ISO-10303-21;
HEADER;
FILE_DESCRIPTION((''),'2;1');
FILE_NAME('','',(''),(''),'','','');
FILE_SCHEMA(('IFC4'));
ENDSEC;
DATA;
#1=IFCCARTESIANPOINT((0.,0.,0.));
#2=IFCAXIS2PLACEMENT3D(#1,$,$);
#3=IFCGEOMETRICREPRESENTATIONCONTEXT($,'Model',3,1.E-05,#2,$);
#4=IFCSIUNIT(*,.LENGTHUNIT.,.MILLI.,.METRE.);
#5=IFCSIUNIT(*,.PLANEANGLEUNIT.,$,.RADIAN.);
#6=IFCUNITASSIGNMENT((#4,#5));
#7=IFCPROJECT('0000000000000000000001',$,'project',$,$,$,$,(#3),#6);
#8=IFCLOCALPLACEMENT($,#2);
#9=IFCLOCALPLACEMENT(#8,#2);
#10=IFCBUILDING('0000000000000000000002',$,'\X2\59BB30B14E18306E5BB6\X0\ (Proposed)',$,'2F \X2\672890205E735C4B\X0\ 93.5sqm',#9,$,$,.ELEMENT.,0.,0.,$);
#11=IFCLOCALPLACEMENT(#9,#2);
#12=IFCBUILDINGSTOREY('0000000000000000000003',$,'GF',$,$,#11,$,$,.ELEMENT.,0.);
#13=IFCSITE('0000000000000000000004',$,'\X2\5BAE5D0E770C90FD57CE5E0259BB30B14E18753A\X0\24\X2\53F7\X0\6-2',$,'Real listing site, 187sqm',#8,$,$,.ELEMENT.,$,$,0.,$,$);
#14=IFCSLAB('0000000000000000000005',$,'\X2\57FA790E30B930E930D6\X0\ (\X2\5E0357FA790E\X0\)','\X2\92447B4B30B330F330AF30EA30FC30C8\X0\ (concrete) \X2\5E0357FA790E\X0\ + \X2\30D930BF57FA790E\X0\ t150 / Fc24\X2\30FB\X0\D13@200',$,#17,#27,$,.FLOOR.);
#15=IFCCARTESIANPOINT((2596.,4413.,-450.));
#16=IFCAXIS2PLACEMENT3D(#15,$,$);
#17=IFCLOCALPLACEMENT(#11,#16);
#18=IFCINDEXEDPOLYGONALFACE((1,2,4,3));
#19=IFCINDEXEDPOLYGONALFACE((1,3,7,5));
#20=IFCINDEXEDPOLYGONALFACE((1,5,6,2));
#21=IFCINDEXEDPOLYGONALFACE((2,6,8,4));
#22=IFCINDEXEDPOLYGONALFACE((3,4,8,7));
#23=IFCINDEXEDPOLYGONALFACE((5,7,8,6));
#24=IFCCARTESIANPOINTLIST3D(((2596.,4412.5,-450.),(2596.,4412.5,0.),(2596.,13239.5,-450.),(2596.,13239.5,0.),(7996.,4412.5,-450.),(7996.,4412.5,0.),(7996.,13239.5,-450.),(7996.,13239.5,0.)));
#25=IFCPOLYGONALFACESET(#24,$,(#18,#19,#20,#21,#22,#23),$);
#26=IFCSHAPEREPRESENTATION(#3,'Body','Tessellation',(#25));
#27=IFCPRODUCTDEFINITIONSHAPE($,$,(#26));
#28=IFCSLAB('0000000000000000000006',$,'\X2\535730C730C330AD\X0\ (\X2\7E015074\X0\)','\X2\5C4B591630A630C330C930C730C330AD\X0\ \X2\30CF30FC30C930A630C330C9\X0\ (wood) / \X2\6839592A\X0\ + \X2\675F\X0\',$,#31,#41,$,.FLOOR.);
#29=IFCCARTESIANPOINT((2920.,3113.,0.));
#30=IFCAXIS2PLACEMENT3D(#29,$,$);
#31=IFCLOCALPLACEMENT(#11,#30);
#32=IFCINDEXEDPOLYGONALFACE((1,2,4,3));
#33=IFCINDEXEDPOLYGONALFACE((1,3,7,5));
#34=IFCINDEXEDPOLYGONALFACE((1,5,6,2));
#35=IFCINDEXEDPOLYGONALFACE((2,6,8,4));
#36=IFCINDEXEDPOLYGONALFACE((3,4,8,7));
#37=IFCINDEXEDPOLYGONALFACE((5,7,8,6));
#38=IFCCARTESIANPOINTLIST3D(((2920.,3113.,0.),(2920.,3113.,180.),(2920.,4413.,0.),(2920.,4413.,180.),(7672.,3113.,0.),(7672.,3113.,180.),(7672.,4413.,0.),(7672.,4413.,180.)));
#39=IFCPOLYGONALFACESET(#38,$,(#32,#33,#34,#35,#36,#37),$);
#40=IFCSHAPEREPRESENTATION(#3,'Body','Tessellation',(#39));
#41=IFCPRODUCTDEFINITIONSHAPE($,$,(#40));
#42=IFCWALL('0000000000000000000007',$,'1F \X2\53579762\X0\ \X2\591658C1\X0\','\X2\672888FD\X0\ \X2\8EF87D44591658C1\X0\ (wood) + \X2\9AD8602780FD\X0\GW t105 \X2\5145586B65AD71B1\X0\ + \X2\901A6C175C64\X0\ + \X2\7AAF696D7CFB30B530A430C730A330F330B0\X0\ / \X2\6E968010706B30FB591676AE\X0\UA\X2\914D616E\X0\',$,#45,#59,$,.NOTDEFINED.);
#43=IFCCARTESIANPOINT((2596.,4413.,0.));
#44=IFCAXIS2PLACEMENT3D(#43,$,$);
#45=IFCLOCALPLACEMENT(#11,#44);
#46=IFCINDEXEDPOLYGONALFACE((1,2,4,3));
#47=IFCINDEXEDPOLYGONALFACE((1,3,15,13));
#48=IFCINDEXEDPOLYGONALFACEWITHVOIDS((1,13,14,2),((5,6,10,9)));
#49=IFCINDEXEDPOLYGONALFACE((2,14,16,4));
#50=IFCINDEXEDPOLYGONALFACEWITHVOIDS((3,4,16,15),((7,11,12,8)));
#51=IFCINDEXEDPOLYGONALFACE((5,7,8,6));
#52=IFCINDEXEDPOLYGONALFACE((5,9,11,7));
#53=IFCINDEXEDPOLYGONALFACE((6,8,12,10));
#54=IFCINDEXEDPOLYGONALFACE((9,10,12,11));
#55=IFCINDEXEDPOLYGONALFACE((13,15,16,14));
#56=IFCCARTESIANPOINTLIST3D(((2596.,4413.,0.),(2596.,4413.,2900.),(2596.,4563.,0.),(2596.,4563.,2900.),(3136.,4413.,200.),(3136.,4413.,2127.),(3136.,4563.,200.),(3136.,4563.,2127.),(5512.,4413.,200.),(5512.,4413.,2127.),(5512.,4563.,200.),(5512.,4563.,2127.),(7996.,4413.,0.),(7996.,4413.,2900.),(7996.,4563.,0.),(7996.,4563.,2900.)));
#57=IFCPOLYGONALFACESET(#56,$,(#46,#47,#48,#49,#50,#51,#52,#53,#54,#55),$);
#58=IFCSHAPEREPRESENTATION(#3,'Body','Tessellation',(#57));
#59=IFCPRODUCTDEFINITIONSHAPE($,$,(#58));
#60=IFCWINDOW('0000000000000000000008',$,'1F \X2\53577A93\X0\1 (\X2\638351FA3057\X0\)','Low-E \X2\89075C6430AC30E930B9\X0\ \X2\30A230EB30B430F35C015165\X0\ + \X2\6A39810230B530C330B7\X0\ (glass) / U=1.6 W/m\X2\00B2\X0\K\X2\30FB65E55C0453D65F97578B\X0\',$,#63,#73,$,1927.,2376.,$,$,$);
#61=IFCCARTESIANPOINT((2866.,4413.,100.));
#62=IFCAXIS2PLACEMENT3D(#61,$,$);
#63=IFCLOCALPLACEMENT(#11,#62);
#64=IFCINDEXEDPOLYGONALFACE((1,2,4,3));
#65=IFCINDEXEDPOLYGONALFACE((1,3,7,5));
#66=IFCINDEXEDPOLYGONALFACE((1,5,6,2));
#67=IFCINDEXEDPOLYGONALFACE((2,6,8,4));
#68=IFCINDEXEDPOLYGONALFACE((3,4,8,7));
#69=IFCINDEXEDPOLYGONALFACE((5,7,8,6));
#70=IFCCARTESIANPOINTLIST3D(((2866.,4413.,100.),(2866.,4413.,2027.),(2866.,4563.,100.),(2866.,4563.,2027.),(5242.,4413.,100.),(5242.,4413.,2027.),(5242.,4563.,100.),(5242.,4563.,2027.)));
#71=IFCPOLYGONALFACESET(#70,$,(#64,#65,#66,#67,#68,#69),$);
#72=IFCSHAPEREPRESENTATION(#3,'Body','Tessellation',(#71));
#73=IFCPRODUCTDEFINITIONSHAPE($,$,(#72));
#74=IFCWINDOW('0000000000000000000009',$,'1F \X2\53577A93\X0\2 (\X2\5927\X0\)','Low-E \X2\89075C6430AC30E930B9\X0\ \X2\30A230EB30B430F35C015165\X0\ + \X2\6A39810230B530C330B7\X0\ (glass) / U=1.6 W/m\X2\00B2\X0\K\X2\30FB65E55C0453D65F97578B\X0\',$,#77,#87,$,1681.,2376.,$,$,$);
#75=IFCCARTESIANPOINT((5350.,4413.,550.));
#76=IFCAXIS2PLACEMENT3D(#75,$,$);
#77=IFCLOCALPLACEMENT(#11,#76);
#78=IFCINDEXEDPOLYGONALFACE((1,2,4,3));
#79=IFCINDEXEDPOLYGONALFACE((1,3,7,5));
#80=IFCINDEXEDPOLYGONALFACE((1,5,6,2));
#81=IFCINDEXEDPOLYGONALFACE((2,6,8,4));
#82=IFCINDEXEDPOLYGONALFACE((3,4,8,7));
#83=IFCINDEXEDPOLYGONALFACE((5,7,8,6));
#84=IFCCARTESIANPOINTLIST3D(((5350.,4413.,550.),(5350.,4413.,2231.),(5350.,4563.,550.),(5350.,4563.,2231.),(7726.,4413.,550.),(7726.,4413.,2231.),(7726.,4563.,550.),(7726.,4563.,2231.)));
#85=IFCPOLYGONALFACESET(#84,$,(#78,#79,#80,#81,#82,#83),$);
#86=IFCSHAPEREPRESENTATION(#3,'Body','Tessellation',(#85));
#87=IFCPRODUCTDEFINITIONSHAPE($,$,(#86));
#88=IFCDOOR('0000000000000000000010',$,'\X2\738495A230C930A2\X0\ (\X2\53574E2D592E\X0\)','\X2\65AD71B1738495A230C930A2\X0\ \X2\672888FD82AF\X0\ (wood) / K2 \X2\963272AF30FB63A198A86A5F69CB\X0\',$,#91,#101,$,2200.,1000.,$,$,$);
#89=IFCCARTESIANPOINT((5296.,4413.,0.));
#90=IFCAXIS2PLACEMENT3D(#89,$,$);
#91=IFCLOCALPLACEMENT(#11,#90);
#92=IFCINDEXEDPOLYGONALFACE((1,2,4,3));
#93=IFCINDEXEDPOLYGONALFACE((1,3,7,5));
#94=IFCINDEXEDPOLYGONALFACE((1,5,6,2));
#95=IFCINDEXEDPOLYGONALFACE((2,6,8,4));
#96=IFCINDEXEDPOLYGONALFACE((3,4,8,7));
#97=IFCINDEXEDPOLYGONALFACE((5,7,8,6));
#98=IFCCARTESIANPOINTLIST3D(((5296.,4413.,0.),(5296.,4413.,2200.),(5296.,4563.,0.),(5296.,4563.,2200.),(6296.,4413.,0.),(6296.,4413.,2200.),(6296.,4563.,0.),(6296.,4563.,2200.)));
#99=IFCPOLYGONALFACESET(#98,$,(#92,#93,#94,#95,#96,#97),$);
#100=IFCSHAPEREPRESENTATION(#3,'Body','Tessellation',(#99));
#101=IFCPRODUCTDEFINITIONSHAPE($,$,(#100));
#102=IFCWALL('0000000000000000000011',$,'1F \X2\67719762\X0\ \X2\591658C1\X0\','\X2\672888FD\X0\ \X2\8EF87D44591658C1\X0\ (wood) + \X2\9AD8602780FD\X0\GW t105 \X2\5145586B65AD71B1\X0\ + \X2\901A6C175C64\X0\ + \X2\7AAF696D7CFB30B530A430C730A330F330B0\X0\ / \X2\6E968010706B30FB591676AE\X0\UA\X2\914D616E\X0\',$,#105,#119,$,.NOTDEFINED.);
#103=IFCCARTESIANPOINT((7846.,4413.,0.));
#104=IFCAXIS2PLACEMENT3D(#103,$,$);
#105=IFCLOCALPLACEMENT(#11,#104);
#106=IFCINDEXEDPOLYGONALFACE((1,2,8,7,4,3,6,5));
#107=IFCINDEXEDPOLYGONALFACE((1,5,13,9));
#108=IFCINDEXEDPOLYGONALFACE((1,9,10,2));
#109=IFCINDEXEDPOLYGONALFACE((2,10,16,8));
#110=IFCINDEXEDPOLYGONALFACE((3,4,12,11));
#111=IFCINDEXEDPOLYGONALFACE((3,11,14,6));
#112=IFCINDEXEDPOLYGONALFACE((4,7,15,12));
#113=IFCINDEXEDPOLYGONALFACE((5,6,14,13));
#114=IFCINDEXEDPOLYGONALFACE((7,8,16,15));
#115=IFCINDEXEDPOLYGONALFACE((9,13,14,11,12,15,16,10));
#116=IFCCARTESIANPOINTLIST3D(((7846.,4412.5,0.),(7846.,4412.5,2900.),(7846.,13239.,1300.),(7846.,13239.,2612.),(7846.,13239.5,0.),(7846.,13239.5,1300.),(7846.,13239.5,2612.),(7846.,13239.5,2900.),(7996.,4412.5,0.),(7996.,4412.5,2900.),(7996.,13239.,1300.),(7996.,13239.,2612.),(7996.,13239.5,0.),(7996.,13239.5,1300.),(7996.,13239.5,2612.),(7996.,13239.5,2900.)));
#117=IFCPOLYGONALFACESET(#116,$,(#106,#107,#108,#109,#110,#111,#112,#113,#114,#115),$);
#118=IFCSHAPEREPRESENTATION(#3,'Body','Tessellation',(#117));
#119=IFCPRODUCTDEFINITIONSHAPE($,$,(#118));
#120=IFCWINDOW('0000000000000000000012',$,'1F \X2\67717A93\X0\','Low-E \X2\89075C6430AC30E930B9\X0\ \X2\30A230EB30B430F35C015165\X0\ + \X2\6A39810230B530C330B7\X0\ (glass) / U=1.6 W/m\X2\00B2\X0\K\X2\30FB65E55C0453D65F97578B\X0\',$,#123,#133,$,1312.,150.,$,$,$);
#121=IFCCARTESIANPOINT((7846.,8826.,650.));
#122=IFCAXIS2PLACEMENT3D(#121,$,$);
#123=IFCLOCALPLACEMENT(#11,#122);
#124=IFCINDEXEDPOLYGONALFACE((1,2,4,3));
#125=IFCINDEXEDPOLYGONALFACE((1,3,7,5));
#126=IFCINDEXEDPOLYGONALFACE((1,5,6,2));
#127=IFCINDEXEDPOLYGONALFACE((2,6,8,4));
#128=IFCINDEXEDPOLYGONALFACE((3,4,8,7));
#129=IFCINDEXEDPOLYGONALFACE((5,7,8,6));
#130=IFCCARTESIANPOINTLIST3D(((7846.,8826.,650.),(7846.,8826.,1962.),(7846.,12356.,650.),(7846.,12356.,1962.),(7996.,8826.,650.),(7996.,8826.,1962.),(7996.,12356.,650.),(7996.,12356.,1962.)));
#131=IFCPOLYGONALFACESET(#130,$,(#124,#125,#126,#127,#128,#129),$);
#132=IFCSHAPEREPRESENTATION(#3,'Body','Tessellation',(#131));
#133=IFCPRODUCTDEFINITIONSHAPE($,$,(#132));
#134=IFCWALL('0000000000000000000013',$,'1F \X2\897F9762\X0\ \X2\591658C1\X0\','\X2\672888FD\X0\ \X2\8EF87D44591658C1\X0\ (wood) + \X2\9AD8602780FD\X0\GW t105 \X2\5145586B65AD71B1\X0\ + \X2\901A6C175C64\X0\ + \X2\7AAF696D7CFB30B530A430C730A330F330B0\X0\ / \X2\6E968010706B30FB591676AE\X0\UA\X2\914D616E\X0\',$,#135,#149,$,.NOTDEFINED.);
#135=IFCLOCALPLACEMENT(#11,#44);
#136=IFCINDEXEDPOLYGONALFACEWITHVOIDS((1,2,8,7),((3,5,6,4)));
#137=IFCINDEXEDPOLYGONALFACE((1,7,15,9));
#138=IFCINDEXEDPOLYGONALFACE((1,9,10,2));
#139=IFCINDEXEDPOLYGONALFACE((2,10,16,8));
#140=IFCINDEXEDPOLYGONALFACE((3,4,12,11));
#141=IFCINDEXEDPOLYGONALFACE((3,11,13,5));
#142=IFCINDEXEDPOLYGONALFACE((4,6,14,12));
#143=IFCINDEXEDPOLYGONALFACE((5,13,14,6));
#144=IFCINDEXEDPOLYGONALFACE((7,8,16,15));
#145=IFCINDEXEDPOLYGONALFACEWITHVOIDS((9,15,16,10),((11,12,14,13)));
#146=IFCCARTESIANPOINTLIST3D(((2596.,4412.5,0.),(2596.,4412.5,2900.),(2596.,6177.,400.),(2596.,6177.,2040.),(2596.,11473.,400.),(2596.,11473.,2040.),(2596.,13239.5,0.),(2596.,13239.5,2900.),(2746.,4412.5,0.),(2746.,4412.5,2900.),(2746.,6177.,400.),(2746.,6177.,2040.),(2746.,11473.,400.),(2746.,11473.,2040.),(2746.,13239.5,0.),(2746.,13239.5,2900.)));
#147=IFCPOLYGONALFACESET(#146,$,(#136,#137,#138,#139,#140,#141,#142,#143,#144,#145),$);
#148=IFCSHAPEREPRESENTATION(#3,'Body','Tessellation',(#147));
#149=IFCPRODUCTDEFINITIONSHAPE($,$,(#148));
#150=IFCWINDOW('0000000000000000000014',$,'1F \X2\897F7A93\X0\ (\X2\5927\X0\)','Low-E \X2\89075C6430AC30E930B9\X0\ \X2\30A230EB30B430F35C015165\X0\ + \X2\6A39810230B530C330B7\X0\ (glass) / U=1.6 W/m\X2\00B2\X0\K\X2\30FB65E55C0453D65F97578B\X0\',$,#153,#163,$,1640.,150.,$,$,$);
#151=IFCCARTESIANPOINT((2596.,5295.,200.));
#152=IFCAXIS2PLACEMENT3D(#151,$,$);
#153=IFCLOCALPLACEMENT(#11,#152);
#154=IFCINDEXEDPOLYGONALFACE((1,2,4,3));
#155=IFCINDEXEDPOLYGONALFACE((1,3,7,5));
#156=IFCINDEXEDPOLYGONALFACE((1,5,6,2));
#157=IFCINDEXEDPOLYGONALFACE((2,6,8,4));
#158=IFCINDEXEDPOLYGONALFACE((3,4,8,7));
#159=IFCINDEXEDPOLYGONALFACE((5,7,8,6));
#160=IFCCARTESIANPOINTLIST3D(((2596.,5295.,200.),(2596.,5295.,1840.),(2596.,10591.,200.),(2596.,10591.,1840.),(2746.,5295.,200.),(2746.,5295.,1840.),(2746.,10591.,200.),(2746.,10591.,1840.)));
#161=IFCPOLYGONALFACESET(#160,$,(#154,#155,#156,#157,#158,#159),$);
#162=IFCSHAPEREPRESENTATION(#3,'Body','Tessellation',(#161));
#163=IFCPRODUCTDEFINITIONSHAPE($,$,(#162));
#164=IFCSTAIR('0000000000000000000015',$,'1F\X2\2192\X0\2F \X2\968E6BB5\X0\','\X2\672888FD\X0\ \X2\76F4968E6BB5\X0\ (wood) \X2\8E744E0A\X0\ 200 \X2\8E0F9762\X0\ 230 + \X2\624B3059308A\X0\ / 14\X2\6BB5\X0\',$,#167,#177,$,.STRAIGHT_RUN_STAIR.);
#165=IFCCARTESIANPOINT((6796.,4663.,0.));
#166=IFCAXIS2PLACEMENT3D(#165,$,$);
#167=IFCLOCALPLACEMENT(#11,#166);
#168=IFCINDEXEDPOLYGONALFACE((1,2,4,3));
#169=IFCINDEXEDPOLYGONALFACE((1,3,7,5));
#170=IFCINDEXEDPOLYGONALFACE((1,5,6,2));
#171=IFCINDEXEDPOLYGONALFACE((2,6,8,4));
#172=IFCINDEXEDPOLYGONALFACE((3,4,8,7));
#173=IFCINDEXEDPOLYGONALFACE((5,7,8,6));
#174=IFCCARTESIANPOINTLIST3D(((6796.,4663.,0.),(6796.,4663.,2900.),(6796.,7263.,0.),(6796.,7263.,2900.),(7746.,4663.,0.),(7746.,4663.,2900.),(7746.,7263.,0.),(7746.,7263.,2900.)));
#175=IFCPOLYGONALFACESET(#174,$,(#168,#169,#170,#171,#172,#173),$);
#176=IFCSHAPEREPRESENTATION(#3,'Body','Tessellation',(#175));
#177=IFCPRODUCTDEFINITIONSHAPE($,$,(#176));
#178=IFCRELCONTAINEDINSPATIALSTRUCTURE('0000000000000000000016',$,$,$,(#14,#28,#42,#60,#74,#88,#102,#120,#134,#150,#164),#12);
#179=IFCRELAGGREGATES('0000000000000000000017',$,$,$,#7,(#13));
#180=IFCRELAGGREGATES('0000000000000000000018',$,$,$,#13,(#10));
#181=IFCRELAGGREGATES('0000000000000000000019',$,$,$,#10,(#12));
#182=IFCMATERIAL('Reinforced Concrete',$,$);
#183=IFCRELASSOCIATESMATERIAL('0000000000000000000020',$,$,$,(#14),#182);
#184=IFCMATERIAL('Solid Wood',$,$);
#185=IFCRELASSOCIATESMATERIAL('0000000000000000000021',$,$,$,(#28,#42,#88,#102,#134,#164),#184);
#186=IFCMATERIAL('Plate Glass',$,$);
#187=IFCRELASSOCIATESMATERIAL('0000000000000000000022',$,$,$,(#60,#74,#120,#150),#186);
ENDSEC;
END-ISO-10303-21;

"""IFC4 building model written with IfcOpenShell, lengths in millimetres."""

from ifc_helpers import new_model, si_unit, frame, frame_2d, origin, place, context, project, spatial, rectangle, extrude, material, element, fill, save


model = new_model("IFC4")

# Units and contexts
model_context = context("Model", 3, precision=1e-05, world=origin())
ifc_project = project(units=[si_unit("LENGTHUNIT", "METRE", prefix="MILLI"), si_unit("PLANEANGLEUNIT", "RADIAN")], contexts=[model_context])

# Site, building, storey
site_placement = place(None, origin())
site = spatial("IfcSite", under=ifc_project, at=site_placement, Name="宮崎県都城市妻ケ丘町24号6-2", ObjectType="Real listing site, 187sqm", CompositionType="ELEMENT", RefElevation=0.0)
building_placement = place(site_placement, origin())
building = spatial("IfcBuilding", under=site, at=building_placement, Name="妻ケ丘の家 (Proposed)", ObjectType="2F 木造平屋 93.5sqm", CompositionType="ELEMENT", ElevationOfRefHeight=0.0, ElevationOfTerrain=0.0)
storey_placement = place(building_placement, origin())
storey = spatial("IfcBuildingStorey", under=building, at=storey_placement, Name="GF", CompositionType="ELEMENT", Elevation=0.0)

# Slabs
ifc_material_1 = material(Name="Reinforced Concrete")
slab_1_placement = place(storey_placement, frame((2596.0, 4413.0, -450.0)))
element("IfcSlab", 1, at=slab_1_placement, inside=storey, material=ifc_material_1, Name="基礎スラブ (布基礎)", Description="鉄筋コンクリート (concrete) 布基礎 + ベタ基礎 t150 / Fc24・D13@200", PredefinedType="FLOOR", context=model_context, shape_type="SweptSolid", body=[
    extrude(rectangle(XDim=5400.0, YDim=8827.0, at=frame_2d((2700.0, 4413.0))), frame((2596.0, 4413.0, -450.0)), (0.0, 0.0, 1.0), 450.0),
])
ifc_material_2 = material(Name="Solid Wood")
slab_2_placement = place(storey_placement, frame((2920.0, 3113.0, 0.0)))
element("IfcSlab", 2, at=slab_2_placement, inside=storey, material=ifc_material_2, Name="南デッキ (縁側)", Description="屋外ウッドデッキ ハードウッド (wood) / 根太 + 束", PredefinedType="FLOOR", context=model_context, shape_type="SweptSolid", body=[
    extrude(rectangle(XDim=4752.0, YDim=1300.0, at=frame_2d((2376.0, 650.0))), frame((2920.0, 3113.0, 0.0)), (0.0, 0.0, 1.0), 180.0),
])

# Wall, openings, windows, door
wall_1_placement = place(storey_placement, frame((2596.0, 4413.0, 0.0)))
wall_1 = element("IfcWall", 3, at=wall_1_placement, inside=storey, material=ifc_material_2, Name="1F 南面 外壁", Description="木製 軸組外壁 (wood) + 高性能GW t105 充填断熱 + 通気層 + 窯業系サイディング / 準耐火・外皮UA配慮", PredefinedType="NOTDEFINED", context=model_context, shape_type="SweptSolid", body=[
    extrude(rectangle(XDim=5400.0, YDim=150.0, at=frame_2d((2700.0, 75.0))), frame((2596.0, 4413.0, 0.0)), (0.0, 0.0, 1.0), 2900.0),
])
opening_1_placement = place(storey_placement, frame((2866.0, 4413.0, 100.0)))
opening_1 = element("IfcOpeningElement", 4, at=opening_1_placement, cuts=wall_1, PredefinedType="NOTDEFINED", context=model_context, shape_type="SweptSolid", body=[
    extrude(rectangle(XDim=2376.0, YDim=150.0, at=frame_2d((1188.0, 75.0))), frame((2866.0, 4413.0, 100.0)), (0.0, 0.0, 1.0), 1927.0),
])
opening_2_placement = place(storey_placement, frame((5350.0, 4413.0, 550.0)))
opening_2 = element("IfcOpeningElement", 5, at=opening_2_placement, cuts=wall_1, PredefinedType="NOTDEFINED", context=model_context, shape_type="SweptSolid", body=[
    extrude(rectangle(XDim=2376.0, YDim=150.0, at=frame_2d((1188.0, 75.0))), frame((5350.0, 4413.0, 550.0)), (0.0, 0.0, 1.0), 1681.0),
])
opening_3_placement = place(storey_placement, frame((5296.0, 4413.0, 0.0)))
opening_3 = element("IfcOpeningElement", 6, at=opening_3_placement, cuts=wall_1, PredefinedType="NOTDEFINED", context=model_context, shape_type="SweptSolid", body=[
    extrude(rectangle(XDim=1000.0, YDim=150.0, at=frame_2d((500.0, 75.0))), frame((5296.0, 4413.0, 0.0)), (0.0, 0.0, 1.0), 2200.0),
])
ifc_material_3 = material(Name="Plate Glass")
window_1_placement = place(storey_placement, frame((2866.0, 4413.0, 100.0)))
window_1 = element("IfcWindow", 7, at=window_1_placement, inside=storey, material=ifc_material_3, Name="1F 南窓1 (掃出し)", Description="Low-E 複層ガラス アルゴン封入 + 樹脂サッシ (glass) / U=1.6 W/m²K・日射取得型", OverallHeight=1927.0, OverallWidth=2376.0, context=model_context, shape_type="SweptSolid", body=[
    extrude(rectangle(XDim=2376.0, YDim=150.0, at=frame_2d((1188.0, 75.0))), frame((2866.0, 4413.0, 100.0)), (0.0, 0.0, 1.0), 1927.0),
])
fill(opening_1, window_1)
window_2_placement = place(storey_placement, frame((5350.0, 4413.0, 550.0)))
window_2 = element("IfcWindow", 8, at=window_2_placement, inside=storey, material=ifc_material_3, Name="1F 南窓2 (大)", Description="Low-E 複層ガラス アルゴン封入 + 樹脂サッシ (glass) / U=1.6 W/m²K・日射取得型", OverallHeight=1681.0, OverallWidth=2376.0, context=model_context, shape_type="SweptSolid", body=[
    extrude(rectangle(XDim=2376.0, YDim=150.0, at=frame_2d((1188.0, 75.0))), frame((5350.0, 4413.0, 550.0)), (0.0, 0.0, 1.0), 1681.0),
])
fill(opening_2, window_2)
door_placement = place(storey_placement, frame((5296.0, 4413.0, 0.0)))
door = element("IfcDoor", 9, at=door_placement, inside=storey, material=ifc_material_2, Name="玄関ドア (南中央)", Description="断熱玄関ドア 木製芯 (wood) / K2 防犯・採風機構", OverallHeight=2200.0, OverallWidth=1000.0, context=model_context, shape_type="SweptSolid", body=[
    extrude(rectangle(XDim=1000.0, YDim=150.0, at=frame_2d((500.0, 75.0))), frame((5296.0, 4413.0, 0.0)), (0.0, 0.0, 1.0), 2200.0),
])
fill(opening_3, door)

# Walls, openings, windows
wall_2_placement = place(storey_placement, frame((7846.0, 4413.0, 0.0)))
wall_2 = element("IfcWall", 10, at=wall_2_placement, inside=storey, material=ifc_material_2, Name="1F 東面 外壁", Description="木製 軸組外壁 (wood) + 高性能GW t105 充填断熱 + 通気層 + 窯業系サイディング / 準耐火・外皮UA配慮", PredefinedType="NOTDEFINED", context=model_context, shape_type="SweptSolid", body=[
    extrude(rectangle(XDim=150.0, YDim=8827.0, at=frame_2d((75.0, 4413.0))), frame((7846.0, 4413.0, 0.0)), (0.0, 0.0, 1.0), 2900.0),
])
opening_4_placement = place(storey_placement, frame((7846.0, 8826.0, 650.0)))
opening_4 = element("IfcOpeningElement", 11, at=opening_4_placement, cuts=wall_2, PredefinedType="NOTDEFINED", context=model_context, shape_type="SweptSolid", body=[
    extrude(rectangle(XDim=150.0, YDim=3530.0, at=frame_2d((75.0, 1765.0))), frame((7846.0, 8826.0, 650.0)), (0.0, 0.0, 1.0), 1312.0),
])
window_3_placement = place(storey_placement, frame((7846.0, 8826.0, 650.0)))
window_3 = element("IfcWindow", 12, at=window_3_placement, inside=storey, material=ifc_material_3, Name="1F 東窓", Description="Low-E 複層ガラス アルゴン封入 + 樹脂サッシ (glass) / U=1.6 W/m²K・日射取得型", OverallHeight=1312.0, OverallWidth=150.0, context=model_context, shape_type="SweptSolid", body=[
    extrude(rectangle(XDim=150.0, YDim=3530.0, at=frame_2d((75.0, 1765.0))), frame((7846.0, 8826.0, 650.0)), (0.0, 0.0, 1.0), 1312.0),
])
fill(opening_4, window_3)
wall_3_placement = place(storey_placement, frame((2596.0, 4413.0, 0.0)))
wall_3 = element("IfcWall", 13, at=wall_3_placement, inside=storey, material=ifc_material_2, Name="1F 西面 外壁", Description="木製 軸組外壁 (wood) + 高性能GW t105 充填断熱 + 通気層 + 窯業系サイディング / 準耐火・外皮UA配慮", PredefinedType="NOTDEFINED", context=model_context, shape_type="SweptSolid", body=[
    extrude(rectangle(XDim=150.0, YDim=8827.0, at=frame_2d((75.0, 4413.0))), frame((2596.0, 4413.0, 0.0)), (0.0, 0.0, 1.0), 2900.0),
])
opening_5_placement = place(storey_placement, frame((2596.0, 5295.0, 200.0)))
opening_5 = element("IfcOpeningElement", 14, at=opening_5_placement, cuts=wall_3, PredefinedType="NOTDEFINED", context=model_context, shape_type="SweptSolid", body=[
    extrude(rectangle(XDim=150.0, YDim=5296.0, at=frame_2d((75.0, 2648.0))), frame((2596.0, 5295.0, 200.0)), (0.0, 0.0, 1.0), 1640.0),
])
window_4_placement = place(storey_placement, frame((2596.0, 5295.0, 200.0)))
window_4 = element("IfcWindow", 15, at=window_4_placement, inside=storey, material=ifc_material_3, Name="1F 西窓 (大)", Description="Low-E 複層ガラス アルゴン封入 + 樹脂サッシ (glass) / U=1.6 W/m²K・日射取得型", OverallHeight=1640.0, OverallWidth=150.0, context=model_context, shape_type="SweptSolid", body=[
    extrude(rectangle(XDim=150.0, YDim=5296.0, at=frame_2d((75.0, 2648.0))), frame((2596.0, 5295.0, 200.0)), (0.0, 0.0, 1.0), 1640.0),
])
fill(opening_5, window_4)

# Stair
stair_placement = place(storey_placement, frame((6796.0, 4663.0, 0.0)))
element("IfcStair", 16, at=stair_placement, inside=storey, material=ifc_material_2, Name="1F→2F 階段", Description="木製 直階段 (wood) 蹴上 200 踏面 230 + 手すり / 14段", PredefinedType="STRAIGHT_RUN_STAIR", context=model_context, shape_type="SweptSolid", body=[
    extrude(rectangle(XDim=950.0, YDim=2600.0, at=frame_2d((475.0, 1300.0))), frame((6796.0, 4663.0, 0.0)), (0.0, 0.0, 1.0), 2900.0),
])

save(model, "model.ifc")
